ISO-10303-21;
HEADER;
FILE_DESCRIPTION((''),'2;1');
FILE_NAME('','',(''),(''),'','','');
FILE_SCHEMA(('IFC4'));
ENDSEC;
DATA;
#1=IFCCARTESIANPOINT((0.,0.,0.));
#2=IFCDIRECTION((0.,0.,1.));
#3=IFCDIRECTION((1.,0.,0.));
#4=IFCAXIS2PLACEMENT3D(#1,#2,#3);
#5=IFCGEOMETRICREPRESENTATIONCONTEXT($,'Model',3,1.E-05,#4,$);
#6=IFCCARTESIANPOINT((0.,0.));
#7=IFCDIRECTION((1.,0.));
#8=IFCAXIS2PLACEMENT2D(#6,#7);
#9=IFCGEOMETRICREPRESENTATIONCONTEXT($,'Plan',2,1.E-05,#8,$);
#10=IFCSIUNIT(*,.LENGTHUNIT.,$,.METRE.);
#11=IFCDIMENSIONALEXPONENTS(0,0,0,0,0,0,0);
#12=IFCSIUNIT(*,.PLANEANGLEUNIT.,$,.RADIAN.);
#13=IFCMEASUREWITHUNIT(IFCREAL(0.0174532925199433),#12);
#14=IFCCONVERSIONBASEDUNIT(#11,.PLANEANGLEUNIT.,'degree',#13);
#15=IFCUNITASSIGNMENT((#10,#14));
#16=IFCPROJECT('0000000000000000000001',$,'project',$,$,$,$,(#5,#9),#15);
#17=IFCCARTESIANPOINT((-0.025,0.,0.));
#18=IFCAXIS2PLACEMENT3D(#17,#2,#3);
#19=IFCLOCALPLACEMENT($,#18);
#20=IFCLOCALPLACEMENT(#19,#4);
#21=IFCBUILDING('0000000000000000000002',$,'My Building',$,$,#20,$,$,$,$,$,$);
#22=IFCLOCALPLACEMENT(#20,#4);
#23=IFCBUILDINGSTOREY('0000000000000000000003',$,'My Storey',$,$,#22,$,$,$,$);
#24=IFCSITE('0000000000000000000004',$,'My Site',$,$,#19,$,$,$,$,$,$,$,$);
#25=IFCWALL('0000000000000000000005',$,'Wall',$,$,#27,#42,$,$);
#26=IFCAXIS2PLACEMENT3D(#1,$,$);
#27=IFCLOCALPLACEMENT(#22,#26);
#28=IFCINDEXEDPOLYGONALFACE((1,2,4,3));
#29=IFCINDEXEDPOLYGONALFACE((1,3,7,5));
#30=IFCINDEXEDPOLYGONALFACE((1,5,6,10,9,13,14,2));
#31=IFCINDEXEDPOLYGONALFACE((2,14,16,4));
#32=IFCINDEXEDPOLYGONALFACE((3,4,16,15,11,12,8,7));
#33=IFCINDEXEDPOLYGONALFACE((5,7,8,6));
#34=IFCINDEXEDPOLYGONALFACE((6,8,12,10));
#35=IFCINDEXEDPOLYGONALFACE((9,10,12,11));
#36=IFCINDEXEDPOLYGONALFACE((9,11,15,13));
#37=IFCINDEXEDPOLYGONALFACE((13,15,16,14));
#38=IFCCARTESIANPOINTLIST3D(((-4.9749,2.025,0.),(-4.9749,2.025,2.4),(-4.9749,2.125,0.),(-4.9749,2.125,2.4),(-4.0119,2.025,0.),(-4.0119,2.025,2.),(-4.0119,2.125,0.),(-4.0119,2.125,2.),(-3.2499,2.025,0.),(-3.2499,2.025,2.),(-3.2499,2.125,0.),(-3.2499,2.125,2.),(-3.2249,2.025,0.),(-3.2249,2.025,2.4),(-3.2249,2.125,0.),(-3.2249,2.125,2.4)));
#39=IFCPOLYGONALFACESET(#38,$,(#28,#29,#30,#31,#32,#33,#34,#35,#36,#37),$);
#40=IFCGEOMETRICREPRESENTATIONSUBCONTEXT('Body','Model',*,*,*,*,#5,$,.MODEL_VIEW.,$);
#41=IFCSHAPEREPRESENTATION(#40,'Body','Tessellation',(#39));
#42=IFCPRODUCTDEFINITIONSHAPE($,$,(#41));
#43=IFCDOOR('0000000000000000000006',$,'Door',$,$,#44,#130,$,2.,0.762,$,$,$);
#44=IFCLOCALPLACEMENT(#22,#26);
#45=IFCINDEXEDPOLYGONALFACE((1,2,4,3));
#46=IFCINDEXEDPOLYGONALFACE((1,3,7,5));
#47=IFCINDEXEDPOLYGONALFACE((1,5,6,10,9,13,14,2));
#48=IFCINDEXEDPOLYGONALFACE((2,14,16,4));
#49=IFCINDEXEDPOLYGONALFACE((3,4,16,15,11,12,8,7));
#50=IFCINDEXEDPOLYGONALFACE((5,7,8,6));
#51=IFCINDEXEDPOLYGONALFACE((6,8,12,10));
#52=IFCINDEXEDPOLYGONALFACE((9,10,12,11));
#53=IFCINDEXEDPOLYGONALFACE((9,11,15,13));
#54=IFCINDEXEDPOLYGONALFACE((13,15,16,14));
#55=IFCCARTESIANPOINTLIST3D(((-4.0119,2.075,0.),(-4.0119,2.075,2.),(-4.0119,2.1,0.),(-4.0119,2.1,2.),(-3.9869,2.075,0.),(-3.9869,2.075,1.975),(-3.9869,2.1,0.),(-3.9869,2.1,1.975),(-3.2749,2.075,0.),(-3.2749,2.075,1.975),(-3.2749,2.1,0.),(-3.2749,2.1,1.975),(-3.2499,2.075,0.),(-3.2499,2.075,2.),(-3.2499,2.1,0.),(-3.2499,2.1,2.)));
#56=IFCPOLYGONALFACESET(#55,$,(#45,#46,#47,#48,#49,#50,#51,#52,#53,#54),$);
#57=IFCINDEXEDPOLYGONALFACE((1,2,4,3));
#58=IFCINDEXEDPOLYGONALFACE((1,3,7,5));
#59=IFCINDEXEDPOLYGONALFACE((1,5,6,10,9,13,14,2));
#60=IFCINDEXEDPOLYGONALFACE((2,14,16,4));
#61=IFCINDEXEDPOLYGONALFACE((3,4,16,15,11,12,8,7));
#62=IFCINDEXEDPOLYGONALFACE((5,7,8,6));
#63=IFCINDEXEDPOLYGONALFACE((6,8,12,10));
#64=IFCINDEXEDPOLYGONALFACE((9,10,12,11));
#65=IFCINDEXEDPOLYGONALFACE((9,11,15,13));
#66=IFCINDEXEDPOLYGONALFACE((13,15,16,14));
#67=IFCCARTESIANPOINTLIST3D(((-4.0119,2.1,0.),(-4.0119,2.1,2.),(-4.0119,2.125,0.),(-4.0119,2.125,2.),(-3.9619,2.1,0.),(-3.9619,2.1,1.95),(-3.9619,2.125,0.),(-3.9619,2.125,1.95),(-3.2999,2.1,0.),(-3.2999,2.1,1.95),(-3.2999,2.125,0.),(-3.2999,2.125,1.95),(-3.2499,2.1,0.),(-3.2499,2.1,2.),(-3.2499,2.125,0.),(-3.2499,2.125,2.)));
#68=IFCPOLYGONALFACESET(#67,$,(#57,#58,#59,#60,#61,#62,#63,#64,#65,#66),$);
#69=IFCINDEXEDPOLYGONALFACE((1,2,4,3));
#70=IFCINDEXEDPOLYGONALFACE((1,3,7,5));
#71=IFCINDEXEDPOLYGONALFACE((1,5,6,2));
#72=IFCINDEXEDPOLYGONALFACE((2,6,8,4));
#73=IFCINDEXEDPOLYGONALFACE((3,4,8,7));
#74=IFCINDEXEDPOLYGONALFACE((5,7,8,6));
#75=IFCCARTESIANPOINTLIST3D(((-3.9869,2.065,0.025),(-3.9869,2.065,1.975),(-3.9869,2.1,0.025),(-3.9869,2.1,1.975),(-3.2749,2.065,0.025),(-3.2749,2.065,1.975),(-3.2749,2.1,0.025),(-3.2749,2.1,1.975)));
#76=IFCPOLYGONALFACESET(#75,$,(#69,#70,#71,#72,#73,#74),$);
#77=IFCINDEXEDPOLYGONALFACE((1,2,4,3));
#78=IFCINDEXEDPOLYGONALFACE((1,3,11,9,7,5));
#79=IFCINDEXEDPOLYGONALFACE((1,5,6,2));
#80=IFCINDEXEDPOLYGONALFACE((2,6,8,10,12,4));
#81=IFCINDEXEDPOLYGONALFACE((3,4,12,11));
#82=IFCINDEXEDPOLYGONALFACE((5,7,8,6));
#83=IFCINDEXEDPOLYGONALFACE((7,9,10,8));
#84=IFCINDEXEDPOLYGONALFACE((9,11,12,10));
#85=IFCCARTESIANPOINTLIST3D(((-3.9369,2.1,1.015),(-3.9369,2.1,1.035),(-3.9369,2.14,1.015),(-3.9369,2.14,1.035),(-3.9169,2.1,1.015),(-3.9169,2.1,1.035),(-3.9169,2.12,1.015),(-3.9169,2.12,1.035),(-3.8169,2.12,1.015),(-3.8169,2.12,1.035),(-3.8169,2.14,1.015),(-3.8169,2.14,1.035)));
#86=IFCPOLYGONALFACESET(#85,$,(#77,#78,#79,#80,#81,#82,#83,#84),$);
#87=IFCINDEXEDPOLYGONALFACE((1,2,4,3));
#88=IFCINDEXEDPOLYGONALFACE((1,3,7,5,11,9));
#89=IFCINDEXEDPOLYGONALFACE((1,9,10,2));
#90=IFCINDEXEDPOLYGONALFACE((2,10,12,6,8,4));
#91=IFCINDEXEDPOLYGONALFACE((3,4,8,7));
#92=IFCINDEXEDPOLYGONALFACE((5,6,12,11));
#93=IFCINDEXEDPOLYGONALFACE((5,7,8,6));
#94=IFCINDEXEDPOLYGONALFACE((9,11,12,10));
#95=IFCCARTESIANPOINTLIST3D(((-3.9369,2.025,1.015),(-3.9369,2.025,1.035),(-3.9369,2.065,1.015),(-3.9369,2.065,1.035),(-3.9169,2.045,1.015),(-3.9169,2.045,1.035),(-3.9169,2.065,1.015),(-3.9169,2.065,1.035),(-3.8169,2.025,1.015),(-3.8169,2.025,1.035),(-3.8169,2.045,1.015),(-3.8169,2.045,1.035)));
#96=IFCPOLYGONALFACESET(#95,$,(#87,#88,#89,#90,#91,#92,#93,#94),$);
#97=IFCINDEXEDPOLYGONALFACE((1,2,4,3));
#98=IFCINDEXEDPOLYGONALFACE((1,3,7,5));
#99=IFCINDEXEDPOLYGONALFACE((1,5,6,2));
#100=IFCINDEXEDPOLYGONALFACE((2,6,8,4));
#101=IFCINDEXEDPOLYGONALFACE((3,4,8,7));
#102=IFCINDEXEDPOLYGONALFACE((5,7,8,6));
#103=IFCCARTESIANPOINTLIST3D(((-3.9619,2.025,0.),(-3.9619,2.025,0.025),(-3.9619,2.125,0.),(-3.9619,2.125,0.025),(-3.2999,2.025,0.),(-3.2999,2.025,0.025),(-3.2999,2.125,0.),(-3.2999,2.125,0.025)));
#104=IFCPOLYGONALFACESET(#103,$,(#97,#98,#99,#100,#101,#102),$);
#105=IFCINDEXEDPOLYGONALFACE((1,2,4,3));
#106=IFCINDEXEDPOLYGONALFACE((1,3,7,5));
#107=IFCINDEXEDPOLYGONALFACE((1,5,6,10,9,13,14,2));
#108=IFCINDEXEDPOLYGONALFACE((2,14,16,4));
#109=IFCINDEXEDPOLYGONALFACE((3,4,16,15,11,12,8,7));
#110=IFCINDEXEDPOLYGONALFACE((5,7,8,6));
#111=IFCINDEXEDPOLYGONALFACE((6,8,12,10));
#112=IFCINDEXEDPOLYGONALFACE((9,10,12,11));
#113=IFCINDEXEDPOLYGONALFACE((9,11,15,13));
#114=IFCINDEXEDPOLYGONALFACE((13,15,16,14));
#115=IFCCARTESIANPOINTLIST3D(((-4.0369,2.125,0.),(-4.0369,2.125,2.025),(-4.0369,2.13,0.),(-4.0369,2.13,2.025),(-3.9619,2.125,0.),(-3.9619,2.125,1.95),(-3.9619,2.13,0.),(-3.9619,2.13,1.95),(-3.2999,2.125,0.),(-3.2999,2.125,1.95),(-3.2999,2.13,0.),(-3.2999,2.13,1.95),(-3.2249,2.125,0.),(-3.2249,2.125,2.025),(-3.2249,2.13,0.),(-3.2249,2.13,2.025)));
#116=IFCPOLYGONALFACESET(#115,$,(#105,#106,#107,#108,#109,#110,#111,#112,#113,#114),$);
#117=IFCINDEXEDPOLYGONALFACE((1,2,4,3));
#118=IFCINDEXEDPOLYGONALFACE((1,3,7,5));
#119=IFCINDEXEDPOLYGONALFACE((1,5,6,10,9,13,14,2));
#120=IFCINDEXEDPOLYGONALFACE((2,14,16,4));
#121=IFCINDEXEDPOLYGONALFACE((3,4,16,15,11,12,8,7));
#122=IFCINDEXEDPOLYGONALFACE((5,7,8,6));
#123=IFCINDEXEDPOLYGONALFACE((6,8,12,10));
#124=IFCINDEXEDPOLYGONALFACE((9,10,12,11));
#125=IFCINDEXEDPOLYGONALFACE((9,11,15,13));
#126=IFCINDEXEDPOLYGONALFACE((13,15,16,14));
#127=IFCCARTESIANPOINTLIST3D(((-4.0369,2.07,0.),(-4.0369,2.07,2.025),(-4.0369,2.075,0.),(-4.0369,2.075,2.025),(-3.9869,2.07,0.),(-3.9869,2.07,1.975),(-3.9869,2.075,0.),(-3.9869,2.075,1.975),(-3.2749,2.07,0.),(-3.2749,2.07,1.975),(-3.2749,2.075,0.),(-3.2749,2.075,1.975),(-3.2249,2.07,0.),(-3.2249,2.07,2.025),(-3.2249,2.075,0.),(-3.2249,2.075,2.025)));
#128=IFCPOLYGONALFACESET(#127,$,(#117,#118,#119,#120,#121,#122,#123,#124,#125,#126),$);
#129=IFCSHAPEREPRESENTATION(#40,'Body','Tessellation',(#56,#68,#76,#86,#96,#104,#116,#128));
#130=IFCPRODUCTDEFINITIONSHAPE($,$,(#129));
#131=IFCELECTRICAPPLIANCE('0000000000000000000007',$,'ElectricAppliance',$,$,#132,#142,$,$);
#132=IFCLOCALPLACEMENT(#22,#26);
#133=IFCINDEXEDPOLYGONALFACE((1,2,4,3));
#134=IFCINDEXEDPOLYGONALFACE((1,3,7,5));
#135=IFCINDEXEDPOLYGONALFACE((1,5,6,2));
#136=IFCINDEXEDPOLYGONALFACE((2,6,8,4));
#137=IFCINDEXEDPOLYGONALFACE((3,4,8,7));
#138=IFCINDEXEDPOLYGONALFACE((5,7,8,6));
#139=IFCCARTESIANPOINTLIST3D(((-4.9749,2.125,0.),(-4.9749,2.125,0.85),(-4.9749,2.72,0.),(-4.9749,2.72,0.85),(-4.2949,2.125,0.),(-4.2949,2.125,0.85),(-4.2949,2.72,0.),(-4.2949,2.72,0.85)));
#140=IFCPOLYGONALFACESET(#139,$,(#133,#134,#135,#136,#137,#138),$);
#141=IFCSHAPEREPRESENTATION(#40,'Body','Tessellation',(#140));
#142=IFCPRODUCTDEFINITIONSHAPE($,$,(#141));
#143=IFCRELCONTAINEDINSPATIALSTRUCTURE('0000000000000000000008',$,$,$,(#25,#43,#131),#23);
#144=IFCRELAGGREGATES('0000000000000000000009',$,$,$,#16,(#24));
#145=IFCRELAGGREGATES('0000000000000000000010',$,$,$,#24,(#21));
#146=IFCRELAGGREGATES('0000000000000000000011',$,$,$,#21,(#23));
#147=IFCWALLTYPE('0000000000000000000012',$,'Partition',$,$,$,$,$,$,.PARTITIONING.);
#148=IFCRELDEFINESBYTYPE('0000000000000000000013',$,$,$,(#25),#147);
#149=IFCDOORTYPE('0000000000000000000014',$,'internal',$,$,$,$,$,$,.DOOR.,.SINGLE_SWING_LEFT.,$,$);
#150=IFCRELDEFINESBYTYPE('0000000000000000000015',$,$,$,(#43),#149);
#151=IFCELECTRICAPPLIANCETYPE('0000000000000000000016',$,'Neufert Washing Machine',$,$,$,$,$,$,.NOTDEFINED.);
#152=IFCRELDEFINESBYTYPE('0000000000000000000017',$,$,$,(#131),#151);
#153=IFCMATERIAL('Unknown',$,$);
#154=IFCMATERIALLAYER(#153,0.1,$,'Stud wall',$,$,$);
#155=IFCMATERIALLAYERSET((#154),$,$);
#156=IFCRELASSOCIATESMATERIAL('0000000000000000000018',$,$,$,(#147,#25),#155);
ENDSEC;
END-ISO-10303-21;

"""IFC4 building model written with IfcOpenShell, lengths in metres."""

from ifc_helpers import new_model, entity, si_unit, converted_unit, frame, origin_with_axes, origin_2d_with_axis, place, context, subcontext, project, spatial, line, indexed_curve, outline, extrude, shape, source, transform, mapped, material, layer, layer_set, layer_usage, type_object, type_shapes, element, fill, save


model = new_model("IFC4")

# Units and contexts
model_context = context("Model", 3, precision=1e-05, world=origin_with_axes())
plan_context = context("Plan", 2, precision=1e-05, world=origin_2d_with_axis())
body_context_1 = subcontext(model_context, "Body", "Model", "MODEL_VIEW")
body_context_2 = subcontext(plan_context, "Body", "Plan", "PLAN_VIEW")
ifc_project = project(units=[si_unit("LENGTHUNIT", "METRE"), converted_unit("PLANEANGLEUNIT", "degree", entity("IfcReal", 0.0174532925199433), si_unit("PLANEANGLEUNIT", "RADIAN"), dimensions=[0, 0, 0, 0, 0, 0, 0])], contexts=[model_context, plan_context])

# Site, building, storey
site_placement = place(None, frame((-0.025, 0.0, 0.0), z_axis=(0.0, 0.0, 1.0), x_axis=(1.0, 0.0, 0.0)))
site = spatial("IfcSite", under=ifc_project, at=site_placement, Name="My Site")
building_placement = place(site_placement, origin_with_axes())
building = spatial("IfcBuilding", under=site, at=building_placement, Name="My Building")
storey_placement = place(building_placement, origin_with_axes())
storey = spatial("IfcBuildingStorey", under=building, at=storey_placement, Name="My Storey")

# Shared definitions
ifc_material = material(Name="Unknown")
shared_shape_1 = source(origin_with_axes(), body_context_1, "Body", "SweptSolid", [
    extrude(outline(indexed_curve([(0.0, 0.0), (0.762, 0.0), (0.762, 2.0), (0.0, 2.0)], segments=[line(1, 2, 3, 4, 1)])), frame((0.0, -0.6, 0.0), z_axis=(0.0, -1.0, 0.0), x_axis=(1.0, 0.0, 0.0)), (0.0, 0.0, -1.0), 1.2),
])
door_type = type_object("IfcDoorType", Name="internal", OperationType="SINGLE_SWING_LEFT", PredefinedType="DOOR")
shared_shape_2 = source(origin_with_axes(), body_context_1, "Body", "SweptSolid", [
    extrude(outline(indexed_curve([(0.0, 0.0), (0.0, 2.0), (0.762, 2.0), (0.762, 0.0), (0.737, 0.0), (0.737, 1.975), (0.025, 1.975), (0.025, 0.0)], segments=[line(1, 2, 3, 4, 5, 6, 7, 8, 1)])), frame((0.0, 0.025, 0.0), z_axis=(0.0, -1.0, 0.0), x_axis=(1.0, 0.0, 0.0)), (0.0, 0.0, -1.0), 0.025),
    extrude(outline(indexed_curve([(0.0, 0.0), (0.0, 2.0), (0.762, 2.0), (0.762, 0.0), (0.712, 0.0), (0.712, 1.95), (0.05, 1.95), (0.05, 0.0)], segments=[line(1, 2, 3, 4, 5, 6, 7, 8, 1)])), frame((0.0, 0.0, 0.0), z_axis=(0.0, -1.0, 0.0), x_axis=(1.0, 0.0, 0.0)), (0.0, 0.0, -1.0), 0.025),
    extrude(outline(indexed_curve([(0.0, 0.0), (0.712, 0.0), (0.712, 0.035), (0.0, 0.035)], segments=[line(1, 2, 3, 4, 1)])), frame((0.025, 0.025, 0.025), z_axis=(0.0, 0.0, 1.0), x_axis=(1.0, 0.0, 0.0)), (0.0, 0.0, 1.0), 1.95),
    extrude(outline(indexed_curve([(0.0, 0.0), (0.0, -0.04), (-0.12, -0.04), (-0.12, -0.02), (-0.02, -0.02), (-0.02, 0.0)], segments=[line(1, 2, 3, 4, 5, 6, 1)])), frame((0.687, 0.025, 1.015), z_axis=(0.0, 0.0, 1.0), x_axis=(1.0, 0.0, 0.0)), (0.0, 0.0, 1.0), 0.02),
    extrude(outline(indexed_curve([(0.0, 0.0), (0.0, 0.04), (-0.12, 0.04), (-0.12, 0.02), (-0.02, 0.02), (-0.02, 0.0)], segments=[line(1, 2, 3, 4, 5, 6, 1)])), frame((0.687, 0.06, 1.015), z_axis=(0.0, 0.0, 1.0), x_axis=(1.0, 0.0, 0.0)), (0.0, 0.0, 1.0), 0.02),
    extrude(outline(indexed_curve([(0.0, 0.0), (0.662, 0.0), (0.662, 0.1), (0.0, 0.1)], segments=[line(1, 2, 3, 4, 1)])), frame((0.05, 0.0, 0.0), z_axis=(0.0, 0.0, 1.0), x_axis=(1.0, 0.0, 0.0)), (0.0, 0.0, 1.0), 0.025),
    extrude(outline(indexed_curve([(0.0, 0.0), (0.0, 2.025), (0.812, 2.025), (0.812, 0.0), (0.737, 0.0), (0.737, 1.95), (0.075, 1.95), (0.075, 0.0)], segments=[line(1, 2, 3, 4, 5, 6, 7, 8, 1)])), frame((-0.025, -0.005, 0.0), z_axis=(0.0, -1.0, 0.0), x_axis=(1.0, 0.0, 0.0)), (0.0, 0.0, -1.0), 0.005),
    extrude(outline(indexed_curve([(0.0, 0.0), (0.0, 2.025), (0.812, 2.025), (0.812, 0.0), (0.762, 0.0), (0.762, 1.975), (0.05, 1.975), (0.05, 0.0)], segments=[line(1, 2, 3, 4, 5, 6, 7, 8, 1)])), frame((-0.025, 0.05, 0.0), z_axis=(0.0, -1.0, 0.0), x_axis=(1.0, 0.0, 0.0)), (0.0, 0.0, -1.0), 0.005),
])
shared_shape_3 = source(origin_with_axes(), body_context_2, "Body", "Curve2D", [
    entity("IfcIndexedPolyCurve", entity("IfcCartesianPointList2D", [[0.0, 0.0], [0.0, 0.05], [0.025, 0.05], [0.025, 0.025], [0.05, 0.025], [0.05, 0.0]]), [entity("IfcLineIndex", [1, 2, 3, 4, 5, 6, 1])]),
    entity("IfcIndexedPolyCurve", entity("IfcCartesianPointList2D", [[0.762, 0.0], [0.762, 0.05], [0.737, 0.05], [0.737, 0.025], [0.712, 0.025], [0.712, 0.0]]), [entity("IfcLineIndex", [1, 2, 3, 4, 5, 6, 1])]),
    entity("IfcTrimmedCurve", entity("IfcEllipse", entity("IfcAxis2Placement2D", entity("IfcCartesianPoint", [0.06, 0.05]), entity("IfcDirection", [1.0, 0.0])), 0.677, 0.712), [entity("IfcCartesianPoint", [0.737, 0.05])], [entity("IfcCartesianPoint", [0.06, 0.762])], True, "CARTESIAN"),
    entity("IfcIndexedPolyCurve", entity("IfcCartesianPointList2D", [[0.025, 0.05], [0.06, 0.05], [0.06, 0.762], [0.025, 0.762]]), [entity("IfcLineIndex", [1, 2, 3, 4, 1])]),
])
type_shapes(door_type, [shared_shape_2, shared_shape_3])

# Wall, opening, door
ifc_layer_1 = layer(ifc_material, 0.1, Name="Stud wall")
ifc_layer_set_1 = layer_set([ifc_layer_1])
wall_type_1 = type_object("IfcWallType", Name="Partition", PredefinedType="PARTITIONING", material=ifc_layer_set_1)
ifc_layer_usage_1 = layer_usage(ifc_layer_set_1, "AXIS2", "POSITIVE", 0.0)
wall_1_placement = place(storey_placement, frame((-3.2249, 2.125, 0.0), z_axis=(0.0, 0.0, 1.0), x_axis=(-1.0, 0.0, 0.0)))
wall_1 = element("IfcWall", 1, at=wall_1_placement, inside=storey, type_object=wall_type_1, material=ifc_layer_usage_1, Name="Wall", context=body_context_1, shape_type="SweptSolid", body=[
    extrude(outline(indexed_curve([(0.0, 0.0), (0.0, 0.1), (1.75, 0.1), (1.75, 0.0), (0.0, 0.0)], self_intersect=False)), origin_with_axes(), (0.0, 0.0, 1.0), 2.4),
])
opening_1_placement = place(wall_1_placement, frame((0.025, 0.0, 0.0), z_axis=(0.0, 0.0, 1.0), x_axis=(1.0, 0.0, 0.0)))
opening_1 = element("IfcOpeningElement", 2, at=opening_1_placement, cuts=wall_1, PredefinedType="OPENING", context=body_context_1, shape_type="MappedRepresentation", body=[
    mapped(shared_shape_1, transform((0.0, 0.0, 0.0), x_axis=(1.0, 0.0, 0.0), y_axis=(0.0, 1.0, 0.0), z_axis=(0.0, 0.0, 1.0), scale=1.0)),
])
door_1_placement = place(opening_1_placement, frame((0.0, 0.0, 0.0), z_axis=(0.0, 0.0, 1.0), x_axis=(1.0, 0.0, 0.0)))
door_1 = element("IfcDoor", 3, at=door_1_placement, inside=storey, type_object=door_type, Name="Door", OverallHeight=2.0, OverallWidth=0.762, shapes=[
    shape(body_context_1, "Body", "MappedRepresentation", [mapped(shared_shape_2, transform((0.0, 0.0, 0.0), x_axis=(1.0, 0.0, 0.0), y_axis=(0.0, 1.0, 0.0), z_axis=(0.0, 0.0, 1.0), scale=1.0))]),
    shape(body_context_2, "Body", "MappedRepresentation", [mapped(shared_shape_3, transform((0.0, 0.0, 0.0), x_axis=(1.0, 0.0, 0.0), y_axis=(0.0, 1.0, 0.0), z_axis=(0.0, 0.0, 1.0), scale=1.0))]),
])
fill(opening_1, door_1)

# Electric appliance
electric_appliance_type_1 = type_object("IfcElectricApplianceType", Name="Neufert Washing Machine", PredefinedType="NOTDEFINED")
shared_shape_4 = source(origin_with_axes(), body_context_1, "Body", "SweptSolid", [
    extrude(outline(indexed_curve([(0.0, 0.0), (0.595, 0.0), (0.595, 0.68), (0.0, 0.68)], segments=[line(1, 2, 3, 4, 1)])), origin_with_axes(), (0.0, 0.0, 1.0), 0.85),
])
shared_shape_5 = source(origin_with_axes(), body_context_2, "Body", "Curve2D", [
    entity("IfcIndexedPolyCurve", entity("IfcCartesianPointList2D", [[0.0, 0.0], [0.595, 0.0], [0.595, 0.68], [0.0, 0.68]]), [entity("IfcLineIndex", [1, 2, 3, 4, 1])]),
    entity("IfcCircle", entity("IfcAxis2Placement2D", entity("IfcCartesianPoint", [0.2975, 0.34])), 0.1785),
    entity("IfcCircle", entity("IfcAxis2Placement2D", entity("IfcCartesianPoint", [0.2975, 0.34])), 0.0595),
])
type_shapes(electric_appliance_type_1, [shared_shape_4, shared_shape_5])
electric_appliance_1_placement = place(storey_placement, frame((-4.2949, 2.125, 0.0), z_axis=(0.0, 0.0, 1.0), x_axis=(0.0, 1.0, 0.0)))
element("IfcElectricAppliance", 4, at=electric_appliance_1_placement, inside=storey, type_object=electric_appliance_type_1, Name="ElectricAppliance", shapes=[
    shape(body_context_1, "Body", "MappedRepresentation", [mapped(shared_shape_4, transform((0.0, 0.0, 0.0), x_axis=(1.0, 0.0, 0.0), y_axis=(0.0, 1.0, 0.0), z_axis=(0.0, 0.0, 1.0), scale=1.0))]),
    shape(body_context_2, "Body", "MappedRepresentation", [mapped(shared_shape_5, transform((0.0, 0.0, 0.0), x_axis=(1.0, 0.0, 0.0), y_axis=(0.0, 1.0, 0.0), z_axis=(0.0, 0.0, 1.0), scale=1.0))]),
])

save(model, "model.ifc")
